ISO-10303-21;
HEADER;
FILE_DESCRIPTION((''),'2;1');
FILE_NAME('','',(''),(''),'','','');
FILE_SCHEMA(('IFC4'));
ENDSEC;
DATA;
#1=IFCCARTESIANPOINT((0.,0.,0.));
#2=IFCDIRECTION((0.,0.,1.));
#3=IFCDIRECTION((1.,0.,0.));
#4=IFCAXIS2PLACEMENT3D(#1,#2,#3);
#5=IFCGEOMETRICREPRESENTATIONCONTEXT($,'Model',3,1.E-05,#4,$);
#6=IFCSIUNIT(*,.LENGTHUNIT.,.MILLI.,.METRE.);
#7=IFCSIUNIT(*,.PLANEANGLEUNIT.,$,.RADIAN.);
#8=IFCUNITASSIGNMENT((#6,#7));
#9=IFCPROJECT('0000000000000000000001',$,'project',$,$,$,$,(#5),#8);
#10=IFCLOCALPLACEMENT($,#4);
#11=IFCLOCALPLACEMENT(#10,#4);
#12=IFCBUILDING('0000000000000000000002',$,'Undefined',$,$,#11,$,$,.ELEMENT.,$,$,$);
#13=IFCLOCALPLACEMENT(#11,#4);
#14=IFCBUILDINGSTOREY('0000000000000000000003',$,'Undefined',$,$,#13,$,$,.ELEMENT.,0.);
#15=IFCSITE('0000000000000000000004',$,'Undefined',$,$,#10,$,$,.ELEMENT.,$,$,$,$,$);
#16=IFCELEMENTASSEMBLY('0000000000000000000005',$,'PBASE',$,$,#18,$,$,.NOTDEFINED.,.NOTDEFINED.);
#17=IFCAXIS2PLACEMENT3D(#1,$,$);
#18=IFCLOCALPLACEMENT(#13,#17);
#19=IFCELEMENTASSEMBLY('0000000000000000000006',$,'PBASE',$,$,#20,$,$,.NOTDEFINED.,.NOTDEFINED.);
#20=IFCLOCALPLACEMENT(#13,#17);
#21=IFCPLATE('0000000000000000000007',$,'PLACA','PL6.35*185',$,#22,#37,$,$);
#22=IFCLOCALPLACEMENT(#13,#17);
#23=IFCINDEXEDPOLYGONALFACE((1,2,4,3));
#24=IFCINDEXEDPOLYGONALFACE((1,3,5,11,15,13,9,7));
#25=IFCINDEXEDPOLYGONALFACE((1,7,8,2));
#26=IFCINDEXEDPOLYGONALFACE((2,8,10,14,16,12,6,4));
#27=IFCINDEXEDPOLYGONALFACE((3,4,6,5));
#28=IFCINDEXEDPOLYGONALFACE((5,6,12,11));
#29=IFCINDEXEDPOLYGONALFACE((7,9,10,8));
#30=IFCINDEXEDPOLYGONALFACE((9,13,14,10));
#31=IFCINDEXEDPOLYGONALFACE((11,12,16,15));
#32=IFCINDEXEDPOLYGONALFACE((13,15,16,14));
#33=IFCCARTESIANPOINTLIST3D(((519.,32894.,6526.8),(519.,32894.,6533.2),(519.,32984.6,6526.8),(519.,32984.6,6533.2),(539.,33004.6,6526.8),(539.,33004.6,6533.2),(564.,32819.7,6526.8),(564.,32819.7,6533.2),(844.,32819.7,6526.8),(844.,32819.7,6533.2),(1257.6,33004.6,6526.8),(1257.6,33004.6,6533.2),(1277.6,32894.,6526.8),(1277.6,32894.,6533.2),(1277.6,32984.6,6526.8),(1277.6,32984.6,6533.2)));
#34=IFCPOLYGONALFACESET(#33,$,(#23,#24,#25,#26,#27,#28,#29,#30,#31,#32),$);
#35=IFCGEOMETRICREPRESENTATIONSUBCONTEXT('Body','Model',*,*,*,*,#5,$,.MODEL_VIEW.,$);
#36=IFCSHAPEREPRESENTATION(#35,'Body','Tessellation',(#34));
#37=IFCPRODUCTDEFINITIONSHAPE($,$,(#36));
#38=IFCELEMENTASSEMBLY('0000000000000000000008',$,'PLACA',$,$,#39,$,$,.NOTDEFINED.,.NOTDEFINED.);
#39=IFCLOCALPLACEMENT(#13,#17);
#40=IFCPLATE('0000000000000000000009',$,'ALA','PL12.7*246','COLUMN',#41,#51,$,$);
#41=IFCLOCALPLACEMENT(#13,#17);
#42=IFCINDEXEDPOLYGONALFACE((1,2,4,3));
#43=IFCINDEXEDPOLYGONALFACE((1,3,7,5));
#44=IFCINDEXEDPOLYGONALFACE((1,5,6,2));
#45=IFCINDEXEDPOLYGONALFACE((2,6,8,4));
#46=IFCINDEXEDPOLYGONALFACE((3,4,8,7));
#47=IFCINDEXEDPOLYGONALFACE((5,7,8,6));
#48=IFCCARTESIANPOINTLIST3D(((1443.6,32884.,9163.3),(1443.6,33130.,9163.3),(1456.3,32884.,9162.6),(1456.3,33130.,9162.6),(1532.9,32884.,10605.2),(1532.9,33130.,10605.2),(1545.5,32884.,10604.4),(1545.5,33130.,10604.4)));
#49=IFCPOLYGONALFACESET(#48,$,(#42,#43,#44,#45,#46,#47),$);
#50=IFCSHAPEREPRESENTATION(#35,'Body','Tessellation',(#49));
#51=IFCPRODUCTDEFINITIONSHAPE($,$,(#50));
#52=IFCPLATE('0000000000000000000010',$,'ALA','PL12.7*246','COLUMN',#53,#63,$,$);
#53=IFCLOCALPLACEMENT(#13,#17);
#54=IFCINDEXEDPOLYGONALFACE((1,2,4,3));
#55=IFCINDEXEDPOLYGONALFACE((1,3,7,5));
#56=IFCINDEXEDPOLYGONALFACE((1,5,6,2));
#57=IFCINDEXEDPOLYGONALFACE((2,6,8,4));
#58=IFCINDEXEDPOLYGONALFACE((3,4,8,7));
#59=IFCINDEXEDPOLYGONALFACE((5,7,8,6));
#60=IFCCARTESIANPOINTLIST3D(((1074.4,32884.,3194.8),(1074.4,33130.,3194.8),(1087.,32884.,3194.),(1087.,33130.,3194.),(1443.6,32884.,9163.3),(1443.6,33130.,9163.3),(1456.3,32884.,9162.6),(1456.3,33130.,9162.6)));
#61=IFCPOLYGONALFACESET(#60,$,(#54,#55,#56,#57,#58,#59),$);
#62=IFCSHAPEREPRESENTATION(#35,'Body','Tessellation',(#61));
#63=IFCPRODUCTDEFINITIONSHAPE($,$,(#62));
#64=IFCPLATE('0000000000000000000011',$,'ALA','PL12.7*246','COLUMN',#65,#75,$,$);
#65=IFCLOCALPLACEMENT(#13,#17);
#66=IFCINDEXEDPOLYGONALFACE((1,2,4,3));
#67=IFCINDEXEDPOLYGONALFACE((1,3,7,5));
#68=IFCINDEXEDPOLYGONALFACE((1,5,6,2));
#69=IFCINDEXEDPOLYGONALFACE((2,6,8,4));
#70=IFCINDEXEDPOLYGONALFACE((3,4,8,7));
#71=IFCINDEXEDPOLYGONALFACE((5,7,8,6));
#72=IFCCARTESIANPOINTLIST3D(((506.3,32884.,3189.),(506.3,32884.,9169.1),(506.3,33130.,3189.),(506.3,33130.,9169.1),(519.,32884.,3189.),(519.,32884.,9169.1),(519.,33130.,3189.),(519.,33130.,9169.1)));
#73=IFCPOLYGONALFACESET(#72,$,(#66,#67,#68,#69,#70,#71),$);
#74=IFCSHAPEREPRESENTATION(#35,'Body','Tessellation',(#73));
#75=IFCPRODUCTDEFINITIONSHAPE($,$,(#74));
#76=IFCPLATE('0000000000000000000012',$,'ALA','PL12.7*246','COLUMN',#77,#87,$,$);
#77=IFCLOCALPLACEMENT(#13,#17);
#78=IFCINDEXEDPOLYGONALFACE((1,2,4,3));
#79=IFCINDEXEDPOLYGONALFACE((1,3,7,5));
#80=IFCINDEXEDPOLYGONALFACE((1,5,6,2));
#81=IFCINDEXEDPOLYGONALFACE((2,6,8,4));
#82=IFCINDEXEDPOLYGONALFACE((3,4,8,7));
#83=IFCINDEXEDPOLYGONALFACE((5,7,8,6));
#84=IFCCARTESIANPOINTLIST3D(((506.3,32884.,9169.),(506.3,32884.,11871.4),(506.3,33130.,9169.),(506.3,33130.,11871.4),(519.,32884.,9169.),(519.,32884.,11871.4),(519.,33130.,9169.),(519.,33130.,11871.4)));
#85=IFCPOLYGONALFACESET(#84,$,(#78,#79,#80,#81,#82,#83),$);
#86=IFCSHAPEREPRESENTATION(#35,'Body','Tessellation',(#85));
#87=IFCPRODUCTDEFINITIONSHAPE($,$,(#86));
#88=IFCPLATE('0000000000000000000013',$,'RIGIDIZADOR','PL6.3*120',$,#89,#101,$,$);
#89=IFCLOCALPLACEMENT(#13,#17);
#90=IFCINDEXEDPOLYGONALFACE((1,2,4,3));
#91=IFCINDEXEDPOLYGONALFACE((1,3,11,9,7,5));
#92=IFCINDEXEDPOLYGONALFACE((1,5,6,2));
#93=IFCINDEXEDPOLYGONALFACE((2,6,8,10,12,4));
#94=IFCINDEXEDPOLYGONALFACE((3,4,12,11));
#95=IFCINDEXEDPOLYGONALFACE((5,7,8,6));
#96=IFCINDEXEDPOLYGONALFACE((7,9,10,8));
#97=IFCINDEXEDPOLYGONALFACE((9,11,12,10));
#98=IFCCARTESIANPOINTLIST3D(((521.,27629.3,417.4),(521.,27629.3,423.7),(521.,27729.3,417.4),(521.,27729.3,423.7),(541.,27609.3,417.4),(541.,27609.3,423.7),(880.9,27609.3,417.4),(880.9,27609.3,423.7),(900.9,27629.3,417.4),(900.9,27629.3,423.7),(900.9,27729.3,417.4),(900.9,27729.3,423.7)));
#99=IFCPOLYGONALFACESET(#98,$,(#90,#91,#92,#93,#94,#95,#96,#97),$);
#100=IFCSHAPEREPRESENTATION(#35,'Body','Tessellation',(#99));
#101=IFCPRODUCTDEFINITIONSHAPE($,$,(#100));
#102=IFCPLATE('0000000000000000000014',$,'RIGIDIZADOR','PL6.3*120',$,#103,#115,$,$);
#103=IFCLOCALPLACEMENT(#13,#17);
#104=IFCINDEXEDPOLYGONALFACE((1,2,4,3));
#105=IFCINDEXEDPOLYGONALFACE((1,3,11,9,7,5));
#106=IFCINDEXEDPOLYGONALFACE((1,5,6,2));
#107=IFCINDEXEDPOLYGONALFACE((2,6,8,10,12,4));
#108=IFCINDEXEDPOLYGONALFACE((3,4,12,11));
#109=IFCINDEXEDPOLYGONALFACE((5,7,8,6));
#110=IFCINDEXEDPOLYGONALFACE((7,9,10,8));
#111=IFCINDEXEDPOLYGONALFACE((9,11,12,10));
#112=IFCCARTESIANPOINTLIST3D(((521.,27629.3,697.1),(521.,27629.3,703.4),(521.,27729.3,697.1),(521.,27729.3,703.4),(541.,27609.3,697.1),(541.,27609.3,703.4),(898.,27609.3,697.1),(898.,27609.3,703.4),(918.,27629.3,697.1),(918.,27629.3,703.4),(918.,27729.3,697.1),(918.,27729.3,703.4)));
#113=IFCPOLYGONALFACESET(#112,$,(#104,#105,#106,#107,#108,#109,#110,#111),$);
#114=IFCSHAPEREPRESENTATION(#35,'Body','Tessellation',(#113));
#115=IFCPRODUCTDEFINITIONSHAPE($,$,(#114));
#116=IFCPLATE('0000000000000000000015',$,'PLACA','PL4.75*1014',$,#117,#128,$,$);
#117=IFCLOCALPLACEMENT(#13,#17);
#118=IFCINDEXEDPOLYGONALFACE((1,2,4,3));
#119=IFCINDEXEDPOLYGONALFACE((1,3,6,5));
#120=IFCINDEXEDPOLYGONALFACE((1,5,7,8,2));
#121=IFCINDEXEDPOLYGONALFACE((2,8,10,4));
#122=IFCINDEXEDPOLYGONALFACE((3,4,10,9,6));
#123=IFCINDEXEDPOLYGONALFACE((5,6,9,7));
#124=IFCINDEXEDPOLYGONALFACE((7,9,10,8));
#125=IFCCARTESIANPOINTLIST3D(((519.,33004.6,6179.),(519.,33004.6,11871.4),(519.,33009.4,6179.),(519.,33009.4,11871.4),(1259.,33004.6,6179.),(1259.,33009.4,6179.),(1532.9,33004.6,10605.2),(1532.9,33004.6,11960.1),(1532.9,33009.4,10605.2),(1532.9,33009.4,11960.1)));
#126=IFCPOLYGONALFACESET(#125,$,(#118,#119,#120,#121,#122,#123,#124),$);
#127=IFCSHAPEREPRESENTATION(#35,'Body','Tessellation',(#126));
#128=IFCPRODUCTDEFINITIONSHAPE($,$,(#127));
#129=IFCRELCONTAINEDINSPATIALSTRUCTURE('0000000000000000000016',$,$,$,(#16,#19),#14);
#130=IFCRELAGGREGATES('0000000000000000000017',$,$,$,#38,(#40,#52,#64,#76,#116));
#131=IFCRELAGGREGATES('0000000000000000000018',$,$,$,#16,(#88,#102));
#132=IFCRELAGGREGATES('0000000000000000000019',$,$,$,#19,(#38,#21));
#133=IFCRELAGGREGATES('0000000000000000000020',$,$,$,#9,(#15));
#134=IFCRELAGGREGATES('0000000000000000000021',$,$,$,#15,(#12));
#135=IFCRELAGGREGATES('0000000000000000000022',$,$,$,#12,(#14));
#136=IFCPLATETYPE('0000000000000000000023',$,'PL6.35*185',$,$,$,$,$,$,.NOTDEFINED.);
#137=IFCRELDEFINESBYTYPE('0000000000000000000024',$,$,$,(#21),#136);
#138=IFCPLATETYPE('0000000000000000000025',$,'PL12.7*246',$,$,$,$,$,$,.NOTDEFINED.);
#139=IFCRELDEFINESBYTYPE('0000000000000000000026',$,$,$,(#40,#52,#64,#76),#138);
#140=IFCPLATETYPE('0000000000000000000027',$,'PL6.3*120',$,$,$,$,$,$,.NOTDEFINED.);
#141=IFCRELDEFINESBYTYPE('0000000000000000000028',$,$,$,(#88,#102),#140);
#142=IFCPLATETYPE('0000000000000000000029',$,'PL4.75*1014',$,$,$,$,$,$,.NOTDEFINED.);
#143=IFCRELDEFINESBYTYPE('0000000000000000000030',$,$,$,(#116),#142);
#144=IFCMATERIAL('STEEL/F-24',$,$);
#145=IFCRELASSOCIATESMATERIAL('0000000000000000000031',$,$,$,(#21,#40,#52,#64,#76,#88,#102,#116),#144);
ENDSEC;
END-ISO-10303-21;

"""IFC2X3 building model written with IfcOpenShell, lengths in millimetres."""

from ifc_helpers import new_model, si_unit, frame, origin_with_axes, place, context, subcontext, project, spatial, polyline, outline, extrude, material, type_object, element, aggregate, save


model = new_model("IFC2X3")

# Units and contexts
model_context = context("Model", 3, precision=1e-05, world=origin_with_axes())
body_context = subcontext(model_context, "Body", "Model", "MODEL_VIEW")
ifc_project = project(units=[si_unit("LENGTHUNIT", "METRE", prefix="MILLI"), si_unit("PLANEANGLEUNIT", "RADIAN")], contexts=[model_context])

# Site, building, storey
site_placement = place(None, origin_with_axes())
site = spatial("IfcSite", under=ifc_project, at=site_placement, Name="Undefined", CompositionType="ELEMENT")
building_placement = place(site_placement, origin_with_axes())
building = spatial("IfcBuilding", under=site, at=building_placement, Name="Undefined", CompositionType="ELEMENT")
storey_placement = place(building_placement, origin_with_axes())
storey = spatial("IfcBuildingStorey", under=building, at=storey_placement, Name="Undefined", CompositionType="ELEMENT", Elevation=0.0)

# Shared definitions
ifc_material_1 = material(Name="STEEL/F-24")

# Element assemblies
assembly_1_placement = place(storey_placement, origin_with_axes())
assembly_1 = element("IfcElementAssembly", 1, at=assembly_1_placement, inside=storey, Name="PBASE", AssemblyPlace="NOTDEFINED", PredefinedType="NOTDEFINED")
assembly_2_placement = place(storey_placement, origin_with_axes())
assembly_2 = element("IfcElementAssembly", 2, at=assembly_2_placement, inside=storey, Name="PBASE", AssemblyPlace="NOTDEFINED", PredefinedType="NOTDEFINED")

# Plate
plate_type_1 = type_object("IfcPlateType", Name="PL6.35*185", PredefinedType="NOTDEFINED")
plate_1_placement = place(assembly_2_placement, frame((519.0, 32894.0, 6530.0), z_axis=(0.000012, 0.0, -1.0), x_axis=(0.0, 1.0, 0.0)))
plate_1 = element("IfcPlate", 3, at=plate_1_placement, type_object=plate_type_1, material=ifc_material_1, Name="PLACA", Description="PL6.35*185", context=body_context, shape_type="SweptSolid", body=[
    extrude(outline(polyline([(0.0, 0.0), (90.6, 0.0), (110.6, 20.0), (110.6, 738.6), (90.6, 758.6), (0.0, 758.6), (-74.3, 325.0), (-74.3, 45.0), (0.0, 0.0)])), frame((0.0, 0.0, -3.2), z_axis=(0.0, 0.0, 1.0), x_axis=(1.0, 0.0, 0.0)), (0.0, 0.0, 1.0), 6.4),
])

# Element assembly, plates
assembly_3_placement = place(assembly_2_placement, origin_with_axes())
assembly_3 = element("IfcElementAssembly", 4, at=assembly_3_placement, Name="PLACA", AssemblyPlace="NOTDEFINED", PredefinedType="NOTDEFINED")
plate_type_2 = type_object("IfcPlateType", Name="PL12.7*246", PredefinedType="NOTDEFINED")
plate_2_placement = place(assembly_3_placement, frame((1450.0, 33007.0, 9163.0), z_axis=(-0.998091, 0.0, 0.061754), x_axis=(0.061754, 0.0, 0.998091)))
plate_2 = element("IfcPlate", 5, at=plate_2_placement, type_object=plate_type_2, material=ifc_material_1, Name="ALA", Description="PL12.7*246", ObjectType="COLUMN", context=body_context, shape_type="SweptSolid", body=[
    extrude(outline(polyline([(0.0, -123.0), (0.0, 123.0), (1444.6, 123.0), (1444.6, -123.0), (0.0, -123.0)])), frame((0.0, 0.0, -6.3), z_axis=(0.0, 0.0, 1.0), x_axis=(1.0, 0.0, 0.0)), (0.0, 0.0, 1.0), 12.7),
])
plate_3_placement = place(assembly_3_placement, frame((1080.7, 33007.0, 3194.4), z_axis=(-0.998091, 0.0, 0.061754), x_axis=(0.061754, 0.0, 0.998091)))
plate_3 = element("IfcPlate", 6, at=plate_3_placement, type_object=plate_type_2, material=ifc_material_1, Name="ALA", Description="PL12.7*246", ObjectType="COLUMN", context=body_context, shape_type="SweptSolid", body=[
    extrude(outline(polyline([(0.0, -123.0), (0.0, 123.0), (5980.0, 123.0), (5980.0, -123.0), (0.0, -123.0)])), frame((0.0, 0.0, -6.3), z_axis=(0.0, 0.0, 1.0), x_axis=(1.0, 0.0, 0.0)), (0.0, 0.0, 1.0), 12.7),
])
plate_4_placement = place(assembly_3_placement, frame((512.6, 33007.0, 3189.0), z_axis=(-1.0, 0.0, 0.0), x_axis=(0.0, 0.0, 1.0)))
plate_4 = element("IfcPlate", 7, at=plate_4_placement, type_object=plate_type_2, material=ifc_material_1, Name="ALA", Description="PL12.7*246", ObjectType="COLUMN", context=body_context, shape_type="SweptSolid", body=[
    extrude(outline(polyline([(0.0, -123.0), (0.0, 123.0), (5980.0, 123.0), (5980.0, -123.0), (0.0, -123.0)])), frame((0.0, 0.0, -6.3), z_axis=(0.0, 0.0, 1.0), x_axis=(1.0, 0.0, 0.0)), (0.0, 0.0, 1.0), 12.7),
])
plate_5_placement = place(assembly_3_placement, frame((512.6, 33007.0, 9169.0), z_axis=(-1.0, 0.0, 0.0), x_axis=(0.0, 0.0, 1.0)))
plate_5 = element("IfcPlate", 8, at=plate_5_placement, type_object=plate_type_2, material=ifc_material_1, Name="ALA", Description="PL12.7*246", ObjectType="COLUMN", context=body_context, shape_type="SweptSolid", body=[
    extrude(outline(polyline([(0.0, -123.0), (0.0, 123.0), (2702.4, 123.0), (2702.4, -123.0), (0.0, -123.0)])), frame((0.0, 0.0, -6.3), z_axis=(0.0, 0.0, 1.0), x_axis=(1.0, 0.0, 0.0)), (0.0, 0.0, 1.0), 12.7),
])

# Plates
plate_type_3 = type_object("IfcPlateType", Name="PL6.3*120", PredefinedType="NOTDEFINED")
plate_6_placement = place(assembly_1_placement, frame((521.0, 27729.3, 420.5), z_axis=(0.0, 0.0, 1.0), x_axis=(0.0, -1.0, 0.0)))
plate_6 = element("IfcPlate", 9, at=plate_6_placement, type_object=plate_type_3, material=ifc_material_1, Name="RIGIDIZADOR", Description="PL6.3*120", context=body_context, shape_type="SweptSolid", body=[
    extrude(outline(polyline([(0.0, 0.0), (100.0, 0.0), (120.0, 20.0), (120.0, 359.9), (100.0, 379.9), (0.0, 379.9), (0.0, 0.0)])), frame((0.0, 0.0, -3.1), z_axis=(0.0, 0.0, 1.0), x_axis=(1.0, 0.0, 0.0)), (0.0, 0.0, 1.0), 6.3),
])
plate_7_placement = place(assembly_1_placement, frame((521.0, 27729.3, 700.2), z_axis=(0.0, 0.0, 1.0), x_axis=(0.0, -1.0, 0.0)))
plate_7 = element("IfcPlate", 10, at=plate_7_placement, type_object=plate_type_3, material=ifc_material_1, Name="RIGIDIZADOR", Description="PL6.3*120", context=body_context, shape_type="SweptSolid", body=[
    extrude(outline(polyline([(0.0, 0.0), (100.0, 0.0), (120.0, 20.0), (120.0, 377.0), (100.0, 397.0), (0.0, 397.0), (0.0, 0.0)])), frame((0.0, 0.0, -3.1), z_axis=(0.0, 0.0, 1.0), x_axis=(1.0, 0.0, 0.0)), (0.0, 0.0, 1.0), 6.3),
])
plate_type_4 = type_object("IfcPlateType", Name="PL4.75*1014", PredefinedType="NOTDEFINED")
plate_8_placement = place(assembly_3_placement, frame((519.0, 33007.0, 6179.0), z_axis=(0.0, 1.0, 0.0), x_axis=(0.0, 0.0, 1.0)))
plate_8 = element("IfcPlate", 11, at=plate_8_placement, type_object=plate_type_4, material=ifc_material_1, Name="PLACA", Description="PL4.75*1014", context=body_context, shape_type="SweptSolid", body=[
    extrude(outline(polyline([(0.0, 0.0), (5692.4, 0.0), (5781.1, 1013.9), (4426.1, 1013.9), (0.0, 740.0), (0.0, 0.0)])), frame((0.0, 0.0, -2.4), z_axis=(0.0, 0.0, 1.0), x_axis=(1.0, 0.0, 0.0)), (0.0, 0.0, 1.0), 4.8),
])
aggregate(assembly_3, [plate_2, plate_3, plate_4, plate_5, plate_8])

aggregate(assembly_1, [plate_6, plate_7])
aggregate(assembly_2, [assembly_3, plate_1])

save(model, "model.ifc")
